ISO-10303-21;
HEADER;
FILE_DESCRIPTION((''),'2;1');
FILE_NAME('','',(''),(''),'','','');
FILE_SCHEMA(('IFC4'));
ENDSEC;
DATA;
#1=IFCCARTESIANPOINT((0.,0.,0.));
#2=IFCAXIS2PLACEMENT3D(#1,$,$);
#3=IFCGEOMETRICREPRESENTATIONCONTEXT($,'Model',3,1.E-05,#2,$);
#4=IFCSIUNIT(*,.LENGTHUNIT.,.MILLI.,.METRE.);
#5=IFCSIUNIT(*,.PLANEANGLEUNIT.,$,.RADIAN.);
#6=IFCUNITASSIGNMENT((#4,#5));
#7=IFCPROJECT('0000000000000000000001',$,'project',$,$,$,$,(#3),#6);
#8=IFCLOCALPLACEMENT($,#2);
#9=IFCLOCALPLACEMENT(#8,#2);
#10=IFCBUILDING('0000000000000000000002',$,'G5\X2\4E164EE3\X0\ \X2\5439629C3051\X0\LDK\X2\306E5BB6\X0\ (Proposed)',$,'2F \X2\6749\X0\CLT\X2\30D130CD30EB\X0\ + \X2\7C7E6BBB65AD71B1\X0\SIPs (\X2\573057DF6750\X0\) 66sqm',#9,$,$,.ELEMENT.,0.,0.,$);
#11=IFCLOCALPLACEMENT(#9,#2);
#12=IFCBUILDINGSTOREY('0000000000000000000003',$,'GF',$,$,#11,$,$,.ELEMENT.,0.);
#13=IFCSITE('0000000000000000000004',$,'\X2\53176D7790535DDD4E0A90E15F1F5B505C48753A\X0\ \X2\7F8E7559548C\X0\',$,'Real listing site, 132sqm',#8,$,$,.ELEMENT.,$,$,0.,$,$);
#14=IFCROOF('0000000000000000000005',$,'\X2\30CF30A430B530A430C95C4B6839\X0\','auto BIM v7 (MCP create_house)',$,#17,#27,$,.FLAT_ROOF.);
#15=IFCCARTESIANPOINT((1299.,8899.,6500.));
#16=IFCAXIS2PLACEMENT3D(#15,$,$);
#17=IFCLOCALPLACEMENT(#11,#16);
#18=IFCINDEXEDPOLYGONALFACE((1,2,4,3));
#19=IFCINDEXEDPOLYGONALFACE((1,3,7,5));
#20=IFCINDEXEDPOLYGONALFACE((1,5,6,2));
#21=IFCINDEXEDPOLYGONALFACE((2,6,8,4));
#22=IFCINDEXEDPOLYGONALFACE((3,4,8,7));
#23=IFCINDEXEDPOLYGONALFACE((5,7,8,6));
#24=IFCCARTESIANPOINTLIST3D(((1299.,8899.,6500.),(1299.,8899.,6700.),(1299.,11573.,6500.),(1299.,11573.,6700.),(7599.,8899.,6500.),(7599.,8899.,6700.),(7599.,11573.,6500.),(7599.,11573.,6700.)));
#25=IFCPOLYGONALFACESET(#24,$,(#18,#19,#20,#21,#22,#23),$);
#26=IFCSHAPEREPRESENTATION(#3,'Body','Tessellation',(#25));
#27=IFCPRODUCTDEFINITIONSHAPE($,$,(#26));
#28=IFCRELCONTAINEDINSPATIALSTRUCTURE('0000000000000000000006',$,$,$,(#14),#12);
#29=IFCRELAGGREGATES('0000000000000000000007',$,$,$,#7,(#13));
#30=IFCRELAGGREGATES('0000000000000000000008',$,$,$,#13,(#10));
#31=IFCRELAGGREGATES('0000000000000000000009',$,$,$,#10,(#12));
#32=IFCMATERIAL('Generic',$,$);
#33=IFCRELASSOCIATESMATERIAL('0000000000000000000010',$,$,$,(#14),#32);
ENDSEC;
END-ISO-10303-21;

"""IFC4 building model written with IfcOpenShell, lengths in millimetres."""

from ifc_helpers import new_model, si_unit, frame, frame_2d, origin, place, context, project, spatial, rectangle, extrude, material, element, save


model = new_model("IFC4")

# Units and contexts
model_context = context("Model", 3, precision=1e-05, world=origin())
ifc_project = project(units=[si_unit("LENGTHUNIT", "METRE", prefix="MILLI"), si_unit("PLANEANGLEUNIT", "RADIAN")], contexts=[model_context])

# Site, building, storey
site_placement = place(None, origin())
site = spatial("IfcSite", under=ifc_project, at=site_placement, Name="北海道川上郡弟子屈町 美留和", ObjectType="Real listing site, 132sqm", CompositionType="ELEMENT", RefElevation=0.0)
building_placement = place(site_placement, origin())
building = spatial("IfcBuilding", under=site, at=building_placement, Name="G5世代 吹抜けLDKの家 (Proposed)", ObjectType="2F 杉CLTパネル + 籾殻断熱SIPs (地域材) 66sqm", CompositionType="ELEMENT", ElevationOfRefHeight=0.0, ElevationOfTerrain=0.0)
storey_placement = place(building_placement, origin())
storey = spatial("IfcBuildingStorey", under=building, at=storey_placement, Name="GF", CompositionType="ELEMENT", Elevation=0.0)

# Shared definitions
ifc_material = material(Name="Generic")

# Roof
roof_placement = place(storey_placement, frame((1299.0, 8899.0, 6500.0)))
element("IfcRoof", 1, at=roof_placement, inside=storey, material=ifc_material, Name="ハイサイド屋根", Description="auto BIM v7 (MCP create_house)", PredefinedType="FLAT_ROOF", context=model_context, shape_type="SweptSolid", body=[
    extrude(rectangle(XDim=6300.0, YDim=2674.0, at=frame_2d((3150.0, 1337.0))), frame((1299.0, 8899.0, 6500.0)), (0.0, 0.0, 1.0), 200.0),
])

save(model, "model.ifc")
